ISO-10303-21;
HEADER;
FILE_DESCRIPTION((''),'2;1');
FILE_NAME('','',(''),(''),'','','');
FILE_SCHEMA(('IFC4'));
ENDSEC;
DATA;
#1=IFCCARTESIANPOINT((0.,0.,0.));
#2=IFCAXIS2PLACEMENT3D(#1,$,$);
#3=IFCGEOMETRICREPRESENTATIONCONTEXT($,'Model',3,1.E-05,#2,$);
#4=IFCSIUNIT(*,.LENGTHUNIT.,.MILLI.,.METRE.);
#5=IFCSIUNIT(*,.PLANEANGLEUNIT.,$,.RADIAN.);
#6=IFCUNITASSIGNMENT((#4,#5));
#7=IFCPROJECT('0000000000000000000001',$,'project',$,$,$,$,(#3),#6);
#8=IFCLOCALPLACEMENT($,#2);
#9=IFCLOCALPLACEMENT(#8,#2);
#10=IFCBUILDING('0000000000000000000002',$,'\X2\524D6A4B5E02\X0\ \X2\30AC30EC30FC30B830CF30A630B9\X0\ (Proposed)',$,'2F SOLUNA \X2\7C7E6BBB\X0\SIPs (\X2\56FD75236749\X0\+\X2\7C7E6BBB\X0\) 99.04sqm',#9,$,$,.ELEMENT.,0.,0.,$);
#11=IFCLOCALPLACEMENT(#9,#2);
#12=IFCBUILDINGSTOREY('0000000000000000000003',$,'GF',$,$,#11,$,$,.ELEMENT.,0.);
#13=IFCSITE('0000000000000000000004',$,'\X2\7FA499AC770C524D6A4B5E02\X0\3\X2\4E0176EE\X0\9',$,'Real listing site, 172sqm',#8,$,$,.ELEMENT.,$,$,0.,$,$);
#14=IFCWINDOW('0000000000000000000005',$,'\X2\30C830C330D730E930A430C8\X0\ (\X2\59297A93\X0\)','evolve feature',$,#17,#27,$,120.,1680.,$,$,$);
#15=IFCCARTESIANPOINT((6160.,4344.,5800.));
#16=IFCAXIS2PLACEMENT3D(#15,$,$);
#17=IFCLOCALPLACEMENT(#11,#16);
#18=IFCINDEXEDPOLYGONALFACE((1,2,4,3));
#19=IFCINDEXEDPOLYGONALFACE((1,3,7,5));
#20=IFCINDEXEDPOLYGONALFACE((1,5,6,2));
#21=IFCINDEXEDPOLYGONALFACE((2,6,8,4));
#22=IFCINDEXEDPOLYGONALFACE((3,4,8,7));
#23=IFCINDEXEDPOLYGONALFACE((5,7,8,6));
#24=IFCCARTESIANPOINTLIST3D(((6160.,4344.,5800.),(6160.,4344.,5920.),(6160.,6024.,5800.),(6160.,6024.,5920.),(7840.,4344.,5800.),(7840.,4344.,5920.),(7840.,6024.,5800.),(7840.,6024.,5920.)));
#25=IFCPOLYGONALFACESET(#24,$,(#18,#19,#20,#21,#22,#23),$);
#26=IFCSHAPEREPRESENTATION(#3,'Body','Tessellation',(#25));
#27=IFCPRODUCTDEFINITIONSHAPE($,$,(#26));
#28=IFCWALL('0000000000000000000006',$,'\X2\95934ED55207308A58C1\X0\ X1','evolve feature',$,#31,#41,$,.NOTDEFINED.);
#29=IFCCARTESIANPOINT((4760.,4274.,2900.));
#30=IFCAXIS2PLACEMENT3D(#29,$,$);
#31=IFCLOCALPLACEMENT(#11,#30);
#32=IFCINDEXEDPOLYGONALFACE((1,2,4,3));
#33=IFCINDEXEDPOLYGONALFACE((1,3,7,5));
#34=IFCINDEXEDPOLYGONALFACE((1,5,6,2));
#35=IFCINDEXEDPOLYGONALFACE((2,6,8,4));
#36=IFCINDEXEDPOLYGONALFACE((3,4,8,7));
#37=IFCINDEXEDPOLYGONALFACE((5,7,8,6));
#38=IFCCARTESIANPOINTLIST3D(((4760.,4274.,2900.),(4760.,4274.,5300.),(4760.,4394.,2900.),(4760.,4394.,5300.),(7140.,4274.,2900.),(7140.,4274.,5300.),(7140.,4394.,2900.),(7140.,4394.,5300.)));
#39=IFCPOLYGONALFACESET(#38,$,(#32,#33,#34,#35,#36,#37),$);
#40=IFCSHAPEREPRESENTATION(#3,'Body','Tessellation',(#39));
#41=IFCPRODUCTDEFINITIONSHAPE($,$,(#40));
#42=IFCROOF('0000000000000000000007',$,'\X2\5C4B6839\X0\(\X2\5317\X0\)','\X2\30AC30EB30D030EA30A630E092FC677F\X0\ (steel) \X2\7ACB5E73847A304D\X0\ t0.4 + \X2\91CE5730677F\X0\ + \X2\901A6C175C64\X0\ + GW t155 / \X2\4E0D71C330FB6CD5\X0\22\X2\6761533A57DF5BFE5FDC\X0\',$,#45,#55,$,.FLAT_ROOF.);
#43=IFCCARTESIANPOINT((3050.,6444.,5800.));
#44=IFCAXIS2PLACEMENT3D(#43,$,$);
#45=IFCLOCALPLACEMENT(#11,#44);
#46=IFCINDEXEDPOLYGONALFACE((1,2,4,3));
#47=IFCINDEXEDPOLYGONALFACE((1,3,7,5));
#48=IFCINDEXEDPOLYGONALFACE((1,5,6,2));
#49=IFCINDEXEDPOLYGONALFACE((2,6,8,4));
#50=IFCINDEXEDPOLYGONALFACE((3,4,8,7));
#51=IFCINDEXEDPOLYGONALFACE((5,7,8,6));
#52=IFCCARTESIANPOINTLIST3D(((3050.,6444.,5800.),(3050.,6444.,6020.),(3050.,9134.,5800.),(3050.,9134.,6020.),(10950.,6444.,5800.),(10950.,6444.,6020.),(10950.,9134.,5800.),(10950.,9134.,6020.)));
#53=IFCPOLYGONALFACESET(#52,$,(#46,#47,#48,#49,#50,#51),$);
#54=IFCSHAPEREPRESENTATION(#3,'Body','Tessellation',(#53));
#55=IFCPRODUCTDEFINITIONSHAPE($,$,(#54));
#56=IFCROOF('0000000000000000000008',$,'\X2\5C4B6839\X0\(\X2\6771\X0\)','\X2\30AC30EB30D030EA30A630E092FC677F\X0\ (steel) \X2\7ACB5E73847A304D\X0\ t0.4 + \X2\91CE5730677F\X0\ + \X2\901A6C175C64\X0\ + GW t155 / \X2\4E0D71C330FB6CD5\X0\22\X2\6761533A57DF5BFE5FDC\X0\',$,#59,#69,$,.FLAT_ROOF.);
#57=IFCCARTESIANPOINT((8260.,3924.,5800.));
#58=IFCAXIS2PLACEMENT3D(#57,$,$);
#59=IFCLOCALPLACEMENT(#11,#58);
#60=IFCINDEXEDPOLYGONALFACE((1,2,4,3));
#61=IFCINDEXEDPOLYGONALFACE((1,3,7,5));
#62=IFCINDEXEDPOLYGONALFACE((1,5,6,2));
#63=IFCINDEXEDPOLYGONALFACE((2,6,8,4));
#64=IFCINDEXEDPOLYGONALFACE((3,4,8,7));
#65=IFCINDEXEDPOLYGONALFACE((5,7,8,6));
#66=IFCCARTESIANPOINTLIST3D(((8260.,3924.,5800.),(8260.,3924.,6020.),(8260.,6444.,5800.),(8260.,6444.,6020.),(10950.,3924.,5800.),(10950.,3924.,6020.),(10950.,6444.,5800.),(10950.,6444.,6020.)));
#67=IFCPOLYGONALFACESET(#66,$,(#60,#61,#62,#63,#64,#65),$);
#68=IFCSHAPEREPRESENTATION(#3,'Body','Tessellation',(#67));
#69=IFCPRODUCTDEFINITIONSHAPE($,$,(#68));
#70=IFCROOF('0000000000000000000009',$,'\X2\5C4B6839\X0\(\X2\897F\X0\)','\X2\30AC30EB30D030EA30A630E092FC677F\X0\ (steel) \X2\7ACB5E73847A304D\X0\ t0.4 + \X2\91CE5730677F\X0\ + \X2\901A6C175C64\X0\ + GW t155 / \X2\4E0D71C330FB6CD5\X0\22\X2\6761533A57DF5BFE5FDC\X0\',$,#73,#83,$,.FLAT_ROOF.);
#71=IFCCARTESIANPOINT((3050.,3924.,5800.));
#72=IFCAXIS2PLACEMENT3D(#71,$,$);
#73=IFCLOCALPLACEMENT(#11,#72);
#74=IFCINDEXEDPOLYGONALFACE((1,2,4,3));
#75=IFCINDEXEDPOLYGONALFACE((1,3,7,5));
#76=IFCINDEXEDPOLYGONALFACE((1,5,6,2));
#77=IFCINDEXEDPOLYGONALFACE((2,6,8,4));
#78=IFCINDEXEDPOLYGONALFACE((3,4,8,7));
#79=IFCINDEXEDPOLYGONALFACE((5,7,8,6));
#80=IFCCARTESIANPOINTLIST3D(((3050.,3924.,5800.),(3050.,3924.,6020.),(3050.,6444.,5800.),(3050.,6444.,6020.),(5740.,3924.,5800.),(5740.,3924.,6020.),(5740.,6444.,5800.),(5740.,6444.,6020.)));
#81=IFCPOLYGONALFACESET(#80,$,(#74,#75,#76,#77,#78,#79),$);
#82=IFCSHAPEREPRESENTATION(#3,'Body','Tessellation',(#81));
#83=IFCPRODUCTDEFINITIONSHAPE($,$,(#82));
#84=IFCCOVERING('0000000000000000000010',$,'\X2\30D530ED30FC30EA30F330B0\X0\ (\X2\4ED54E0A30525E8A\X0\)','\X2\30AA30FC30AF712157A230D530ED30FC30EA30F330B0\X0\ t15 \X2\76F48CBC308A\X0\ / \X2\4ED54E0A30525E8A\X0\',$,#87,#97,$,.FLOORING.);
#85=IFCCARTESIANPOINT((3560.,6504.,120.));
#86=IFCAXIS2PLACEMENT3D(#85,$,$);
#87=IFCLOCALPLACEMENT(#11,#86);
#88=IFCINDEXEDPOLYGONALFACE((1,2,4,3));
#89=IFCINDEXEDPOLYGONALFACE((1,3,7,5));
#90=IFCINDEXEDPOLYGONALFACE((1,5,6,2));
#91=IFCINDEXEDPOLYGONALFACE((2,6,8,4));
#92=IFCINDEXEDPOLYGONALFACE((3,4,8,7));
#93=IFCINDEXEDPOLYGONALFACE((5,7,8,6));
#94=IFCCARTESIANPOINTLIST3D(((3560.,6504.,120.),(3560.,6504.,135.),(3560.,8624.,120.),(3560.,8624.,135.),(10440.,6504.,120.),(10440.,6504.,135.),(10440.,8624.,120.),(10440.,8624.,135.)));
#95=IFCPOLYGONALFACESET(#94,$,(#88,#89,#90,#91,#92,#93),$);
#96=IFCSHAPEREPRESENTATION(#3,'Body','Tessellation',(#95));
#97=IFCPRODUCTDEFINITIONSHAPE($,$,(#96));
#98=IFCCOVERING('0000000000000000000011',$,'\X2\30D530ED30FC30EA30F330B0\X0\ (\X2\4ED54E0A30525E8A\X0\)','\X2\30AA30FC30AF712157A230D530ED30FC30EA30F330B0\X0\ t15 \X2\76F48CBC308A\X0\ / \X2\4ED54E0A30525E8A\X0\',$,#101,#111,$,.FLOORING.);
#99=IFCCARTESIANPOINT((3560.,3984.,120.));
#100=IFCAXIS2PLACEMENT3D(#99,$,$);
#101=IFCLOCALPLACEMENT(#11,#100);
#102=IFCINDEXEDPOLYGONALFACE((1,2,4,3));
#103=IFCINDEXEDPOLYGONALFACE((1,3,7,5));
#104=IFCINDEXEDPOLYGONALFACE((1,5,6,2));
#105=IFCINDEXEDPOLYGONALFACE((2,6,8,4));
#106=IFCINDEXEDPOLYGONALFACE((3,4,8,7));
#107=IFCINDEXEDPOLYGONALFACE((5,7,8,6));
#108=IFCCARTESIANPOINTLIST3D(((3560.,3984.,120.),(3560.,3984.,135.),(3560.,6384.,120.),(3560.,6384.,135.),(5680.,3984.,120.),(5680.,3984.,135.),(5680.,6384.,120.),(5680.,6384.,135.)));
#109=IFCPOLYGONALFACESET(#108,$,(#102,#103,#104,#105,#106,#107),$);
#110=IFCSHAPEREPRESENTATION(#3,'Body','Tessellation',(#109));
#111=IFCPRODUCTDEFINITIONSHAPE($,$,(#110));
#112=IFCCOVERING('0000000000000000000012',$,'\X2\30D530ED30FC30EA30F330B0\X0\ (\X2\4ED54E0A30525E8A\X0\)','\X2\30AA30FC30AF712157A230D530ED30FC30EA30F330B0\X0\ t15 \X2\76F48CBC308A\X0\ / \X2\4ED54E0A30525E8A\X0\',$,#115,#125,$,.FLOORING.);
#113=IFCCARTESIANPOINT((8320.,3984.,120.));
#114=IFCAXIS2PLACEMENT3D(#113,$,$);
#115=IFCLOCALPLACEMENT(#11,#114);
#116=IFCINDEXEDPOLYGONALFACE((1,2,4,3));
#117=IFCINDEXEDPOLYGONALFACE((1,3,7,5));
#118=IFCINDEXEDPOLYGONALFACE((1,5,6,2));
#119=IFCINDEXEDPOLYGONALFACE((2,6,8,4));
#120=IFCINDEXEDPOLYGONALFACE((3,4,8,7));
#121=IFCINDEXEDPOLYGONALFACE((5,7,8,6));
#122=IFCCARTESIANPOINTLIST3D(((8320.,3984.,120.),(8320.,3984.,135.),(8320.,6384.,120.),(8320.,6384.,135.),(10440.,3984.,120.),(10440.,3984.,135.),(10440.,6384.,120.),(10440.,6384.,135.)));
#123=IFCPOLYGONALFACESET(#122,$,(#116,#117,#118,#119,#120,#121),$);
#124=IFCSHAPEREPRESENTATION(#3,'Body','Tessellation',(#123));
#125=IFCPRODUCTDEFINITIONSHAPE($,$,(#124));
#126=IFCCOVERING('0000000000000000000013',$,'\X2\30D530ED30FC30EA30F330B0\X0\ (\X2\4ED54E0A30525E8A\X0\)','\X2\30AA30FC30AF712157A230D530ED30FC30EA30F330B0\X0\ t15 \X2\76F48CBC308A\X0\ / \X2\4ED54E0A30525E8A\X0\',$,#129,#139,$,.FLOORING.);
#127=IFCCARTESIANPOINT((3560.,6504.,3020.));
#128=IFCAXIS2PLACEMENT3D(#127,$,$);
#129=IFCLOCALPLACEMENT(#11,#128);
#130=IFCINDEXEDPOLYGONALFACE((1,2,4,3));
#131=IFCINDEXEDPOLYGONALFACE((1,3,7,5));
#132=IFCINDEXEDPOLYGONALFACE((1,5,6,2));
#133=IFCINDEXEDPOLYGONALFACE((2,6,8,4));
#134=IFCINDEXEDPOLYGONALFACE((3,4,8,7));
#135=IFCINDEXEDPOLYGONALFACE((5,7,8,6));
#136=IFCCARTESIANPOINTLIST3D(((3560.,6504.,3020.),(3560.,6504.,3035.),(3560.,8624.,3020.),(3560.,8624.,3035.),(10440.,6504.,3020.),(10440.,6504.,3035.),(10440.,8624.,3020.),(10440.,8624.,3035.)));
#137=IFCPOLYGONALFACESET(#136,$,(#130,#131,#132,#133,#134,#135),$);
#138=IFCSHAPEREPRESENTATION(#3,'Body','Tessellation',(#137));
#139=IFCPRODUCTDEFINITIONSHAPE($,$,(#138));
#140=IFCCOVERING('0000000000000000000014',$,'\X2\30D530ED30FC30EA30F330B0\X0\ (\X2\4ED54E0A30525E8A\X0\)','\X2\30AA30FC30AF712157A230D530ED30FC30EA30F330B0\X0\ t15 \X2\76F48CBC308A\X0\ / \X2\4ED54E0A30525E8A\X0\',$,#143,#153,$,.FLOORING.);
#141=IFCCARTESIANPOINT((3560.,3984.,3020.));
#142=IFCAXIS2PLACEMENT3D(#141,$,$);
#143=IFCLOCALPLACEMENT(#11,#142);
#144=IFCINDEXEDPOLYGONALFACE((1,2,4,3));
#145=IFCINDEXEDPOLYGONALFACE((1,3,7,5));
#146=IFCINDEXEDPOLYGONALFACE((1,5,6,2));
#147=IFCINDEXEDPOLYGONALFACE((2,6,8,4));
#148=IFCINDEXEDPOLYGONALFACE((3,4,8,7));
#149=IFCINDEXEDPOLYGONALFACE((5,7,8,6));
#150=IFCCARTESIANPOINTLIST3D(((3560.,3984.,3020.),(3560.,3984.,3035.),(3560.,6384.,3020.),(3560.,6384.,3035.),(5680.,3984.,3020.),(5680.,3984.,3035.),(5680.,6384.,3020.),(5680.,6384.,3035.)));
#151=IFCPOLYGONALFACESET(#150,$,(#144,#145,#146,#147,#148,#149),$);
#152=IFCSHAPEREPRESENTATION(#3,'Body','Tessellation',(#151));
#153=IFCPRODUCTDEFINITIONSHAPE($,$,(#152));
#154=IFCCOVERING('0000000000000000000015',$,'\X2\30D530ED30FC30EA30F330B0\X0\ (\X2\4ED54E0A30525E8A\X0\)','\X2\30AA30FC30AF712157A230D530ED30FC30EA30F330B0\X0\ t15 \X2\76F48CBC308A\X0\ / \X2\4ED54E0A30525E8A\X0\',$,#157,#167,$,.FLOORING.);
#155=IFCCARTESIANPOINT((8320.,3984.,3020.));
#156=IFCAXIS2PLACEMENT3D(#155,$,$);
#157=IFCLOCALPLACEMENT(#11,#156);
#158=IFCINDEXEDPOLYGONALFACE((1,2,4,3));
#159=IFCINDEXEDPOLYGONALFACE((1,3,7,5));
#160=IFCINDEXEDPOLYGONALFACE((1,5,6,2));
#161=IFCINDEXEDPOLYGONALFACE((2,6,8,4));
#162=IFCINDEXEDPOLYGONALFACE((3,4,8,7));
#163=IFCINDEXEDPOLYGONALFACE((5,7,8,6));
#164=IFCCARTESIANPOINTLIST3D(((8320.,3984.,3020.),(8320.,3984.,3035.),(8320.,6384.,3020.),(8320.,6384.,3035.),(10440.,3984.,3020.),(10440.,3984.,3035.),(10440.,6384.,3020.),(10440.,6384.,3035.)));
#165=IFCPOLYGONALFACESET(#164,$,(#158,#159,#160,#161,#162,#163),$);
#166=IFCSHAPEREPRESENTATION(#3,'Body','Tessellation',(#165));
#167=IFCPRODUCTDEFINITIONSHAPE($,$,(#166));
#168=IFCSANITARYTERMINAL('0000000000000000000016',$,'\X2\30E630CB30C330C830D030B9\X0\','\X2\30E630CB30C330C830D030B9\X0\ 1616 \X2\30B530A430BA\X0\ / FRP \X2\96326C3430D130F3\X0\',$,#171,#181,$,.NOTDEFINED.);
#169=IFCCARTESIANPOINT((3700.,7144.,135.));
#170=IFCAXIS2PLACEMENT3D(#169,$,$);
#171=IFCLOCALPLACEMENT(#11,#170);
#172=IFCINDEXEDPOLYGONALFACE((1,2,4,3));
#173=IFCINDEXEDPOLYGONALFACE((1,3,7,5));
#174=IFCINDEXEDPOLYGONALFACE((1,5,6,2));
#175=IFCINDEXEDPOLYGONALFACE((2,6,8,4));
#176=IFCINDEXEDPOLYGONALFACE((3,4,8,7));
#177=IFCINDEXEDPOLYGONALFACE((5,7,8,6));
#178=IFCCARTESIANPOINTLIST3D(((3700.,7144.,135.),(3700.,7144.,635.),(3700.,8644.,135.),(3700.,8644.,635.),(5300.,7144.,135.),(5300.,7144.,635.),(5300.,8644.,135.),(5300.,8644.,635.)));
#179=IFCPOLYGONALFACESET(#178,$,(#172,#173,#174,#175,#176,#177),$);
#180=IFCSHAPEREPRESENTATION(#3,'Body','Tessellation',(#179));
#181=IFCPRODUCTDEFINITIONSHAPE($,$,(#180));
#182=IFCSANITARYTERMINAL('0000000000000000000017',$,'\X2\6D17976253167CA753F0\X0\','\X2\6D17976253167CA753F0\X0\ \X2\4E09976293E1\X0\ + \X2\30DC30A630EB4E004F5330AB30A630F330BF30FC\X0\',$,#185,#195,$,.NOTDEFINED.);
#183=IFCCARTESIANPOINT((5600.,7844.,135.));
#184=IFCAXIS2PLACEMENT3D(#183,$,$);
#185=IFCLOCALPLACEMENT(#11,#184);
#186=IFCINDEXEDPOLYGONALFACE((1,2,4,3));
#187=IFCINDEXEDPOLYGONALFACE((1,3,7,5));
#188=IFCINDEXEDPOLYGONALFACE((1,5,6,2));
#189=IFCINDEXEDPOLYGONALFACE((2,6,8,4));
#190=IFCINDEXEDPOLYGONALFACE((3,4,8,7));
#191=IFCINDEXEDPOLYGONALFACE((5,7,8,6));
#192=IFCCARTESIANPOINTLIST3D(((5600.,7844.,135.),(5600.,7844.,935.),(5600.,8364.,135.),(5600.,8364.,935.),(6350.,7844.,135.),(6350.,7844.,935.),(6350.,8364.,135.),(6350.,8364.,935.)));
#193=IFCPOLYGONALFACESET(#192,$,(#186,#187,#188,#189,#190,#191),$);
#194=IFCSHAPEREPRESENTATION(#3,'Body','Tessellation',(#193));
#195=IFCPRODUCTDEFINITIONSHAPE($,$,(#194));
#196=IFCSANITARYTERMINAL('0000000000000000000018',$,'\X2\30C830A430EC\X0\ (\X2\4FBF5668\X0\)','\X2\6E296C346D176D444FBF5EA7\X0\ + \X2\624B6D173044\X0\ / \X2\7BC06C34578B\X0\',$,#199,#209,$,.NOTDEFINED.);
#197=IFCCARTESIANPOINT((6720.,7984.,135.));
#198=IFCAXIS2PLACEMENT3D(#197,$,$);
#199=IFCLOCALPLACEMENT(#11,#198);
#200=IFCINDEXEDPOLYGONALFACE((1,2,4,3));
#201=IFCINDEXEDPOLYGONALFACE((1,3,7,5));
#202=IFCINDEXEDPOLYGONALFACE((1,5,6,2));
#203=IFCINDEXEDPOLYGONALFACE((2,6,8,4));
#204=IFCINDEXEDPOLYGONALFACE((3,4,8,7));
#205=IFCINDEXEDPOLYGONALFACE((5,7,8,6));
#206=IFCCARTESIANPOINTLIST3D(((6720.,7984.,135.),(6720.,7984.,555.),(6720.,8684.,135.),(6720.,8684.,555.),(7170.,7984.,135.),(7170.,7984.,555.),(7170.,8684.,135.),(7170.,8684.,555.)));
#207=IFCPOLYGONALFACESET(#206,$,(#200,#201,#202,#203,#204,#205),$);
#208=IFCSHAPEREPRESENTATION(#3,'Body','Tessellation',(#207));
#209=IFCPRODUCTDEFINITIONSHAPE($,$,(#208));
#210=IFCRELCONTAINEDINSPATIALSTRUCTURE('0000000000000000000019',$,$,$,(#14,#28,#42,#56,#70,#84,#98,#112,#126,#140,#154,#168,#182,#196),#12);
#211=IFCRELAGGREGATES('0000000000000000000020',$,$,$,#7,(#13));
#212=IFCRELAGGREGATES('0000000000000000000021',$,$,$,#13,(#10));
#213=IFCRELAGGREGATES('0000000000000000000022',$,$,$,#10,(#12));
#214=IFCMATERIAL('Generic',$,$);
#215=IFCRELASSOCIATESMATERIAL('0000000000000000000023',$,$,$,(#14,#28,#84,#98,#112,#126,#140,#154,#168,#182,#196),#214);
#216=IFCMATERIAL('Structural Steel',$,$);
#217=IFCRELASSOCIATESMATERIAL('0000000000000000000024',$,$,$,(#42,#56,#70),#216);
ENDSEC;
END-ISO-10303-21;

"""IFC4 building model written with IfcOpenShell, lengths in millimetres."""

from ifc_helpers import new_model, si_unit, frame, frame_2d, origin, place, context, project, spatial, rectangle, extrude, material, element, save


model = new_model("IFC4")

# Units and contexts
model_context = context("Model", 3, precision=1e-05, world=origin())
ifc_project = project(units=[si_unit("LENGTHUNIT", "METRE", prefix="MILLI"), si_unit("PLANEANGLEUNIT", "RADIAN")], contexts=[model_context])

# Site, building, storey
site_placement = place(None, origin())
site = spatial("IfcSite", under=ifc_project, at=site_placement, Name="群馬県前橋市3丁目9", ObjectType="Real listing site, 172sqm", CompositionType="ELEMENT", RefElevation=0.0)
building_placement = place(site_placement, origin())
building = spatial("IfcBuilding", under=site, at=building_placement, Name="前橋市 ガレージハウス (Proposed)", ObjectType="2F SOLUNA 籾殻SIPs (国産杉+籾殻) 99.04sqm", CompositionType="ELEMENT", ElevationOfRefHeight=0.0, ElevationOfTerrain=0.0)
storey_placement = place(building_placement, origin())
storey = spatial("IfcBuildingStorey", under=building, at=storey_placement, Name="GF", CompositionType="ELEMENT", Elevation=0.0)

# Window
ifc_material_1 = material(Name="Generic")
window_1_placement = place(storey_placement, frame((6160.0, 4344.0, 5800.0)))
element("IfcWindow", 1, at=window_1_placement, inside=storey, material=ifc_material_1, Name="トップライト (天窓)", Description="evolve feature", OverallHeight=120.0, OverallWidth=1680.0, context=model_context, shape_type="SweptSolid", body=[
    extrude(rectangle(XDim=1680.0, YDim=1680.0, at=frame_2d((840.0, 840.0))), frame((6160.0, 4344.0, 5800.0)), (0.0, 0.0, 1.0), 120.0),
])

# Wall
wall_1_placement = place(storey_placement, frame((4760.0, 4274.0, 2900.0)))
element("IfcWall", 2, at=wall_1_placement, inside=storey, material=ifc_material_1, Name="間仕切り壁 X1", Description="evolve feature", PredefinedType="NOTDEFINED", context=model_context, shape_type="SweptSolid", body=[
    extrude(rectangle(XDim=2380.0, YDim=120.0, at=frame_2d((1190.0, 60.0))), frame((4760.0, 4274.0, 2900.0)), (0.0, 0.0, 1.0), 2400.0),
])

# Roofs
ifc_material_2 = material(Name="Structural Steel")
roof_1_placement = place(storey_placement, frame((3050.0, 6444.0, 5800.0)))
element("IfcRoof", 3, at=roof_1_placement, inside=storey, material=ifc_material_2, Name="屋根(北)", Description="ガルバリウム鋼板 (steel) 立平葺き t0.4 + 野地板 + 通気層 + GW t155 / 不燃・法22条区域対応", PredefinedType="FLAT_ROOF", context=model_context, shape_type="SweptSolid", body=[
    extrude(rectangle(XDim=7900.0, YDim=2690.0, at=frame_2d((3950.0, 1345.0))), frame((3050.0, 6444.0, 5800.0)), (0.0, 0.0, 1.0), 220.0),
])
roof_2_placement = place(storey_placement, frame((8260.0, 3924.0, 5800.0)))
element("IfcRoof", 4, at=roof_2_placement, inside=storey, material=ifc_material_2, Name="屋根(東)", Description="ガルバリウム鋼板 (steel) 立平葺き t0.4 + 野地板 + 通気層 + GW t155 / 不燃・法22条区域対応", PredefinedType="FLAT_ROOF", context=model_context, shape_type="SweptSolid", body=[
    extrude(rectangle(XDim=2690.0, YDim=2520.0, at=frame_2d((1345.0, 1260.0))), frame((8260.0, 3924.0, 5800.0)), (0.0, 0.0, 1.0), 220.0),
])
roof_3_placement = place(storey_placement, frame((3050.0, 3924.0, 5800.0)))
element("IfcRoof", 5, at=roof_3_placement, inside=storey, material=ifc_material_2, Name="屋根(西)", Description="ガルバリウム鋼板 (steel) 立平葺き t0.4 + 野地板 + 通気層 + GW t155 / 不燃・法22条区域対応", PredefinedType="FLAT_ROOF", context=model_context, shape_type="SweptSolid", body=[
    extrude(rectangle(XDim=2690.0, YDim=2520.0, at=frame_2d((1345.0, 1260.0))), frame((3050.0, 3924.0, 5800.0)), (0.0, 0.0, 1.0), 220.0),
])

# Coverings
covering_1_placement = place(storey_placement, frame((3560.0, 6504.0, 120.0)))
element("IfcCovering", 6, at=covering_1_placement, inside=storey, material=ifc_material_1, Name="フローリング (仕上げ床)", Description="オーク無垢フローリング t15 直貼り / 仕上げ床", PredefinedType="FLOORING", context=model_context, shape_type="SweptSolid", body=[
    extrude(rectangle(XDim=6880.0, YDim=2120.0, at=frame_2d((3440.0, 1060.0))), frame((3560.0, 6504.0, 120.0)), (0.0, 0.0, 1.0), 15.0),
])
covering_2_placement = place(storey_placement, frame((3560.0, 3984.0, 120.0)))
element("IfcCovering", 7, at=covering_2_placement, inside=storey, material=ifc_material_1, Name="フローリング (仕上げ床)", Description="オーク無垢フローリング t15 直貼り / 仕上げ床", PredefinedType="FLOORING", context=model_context, shape_type="SweptSolid", body=[
    extrude(rectangle(XDim=2120.0, YDim=2400.0, at=frame_2d((1060.0, 1200.0))), frame((3560.0, 3984.0, 120.0)), (0.0, 0.0, 1.0), 15.0),
])
covering_3_placement = place(storey_placement, frame((8320.0, 3984.0, 120.0)))
element("IfcCovering", 8, at=covering_3_placement, inside=storey, material=ifc_material_1, Name="フローリング (仕上げ床)", Description="オーク無垢フローリング t15 直貼り / 仕上げ床", PredefinedType="FLOORING", context=model_context, shape_type="SweptSolid", body=[
    extrude(rectangle(XDim=2120.0, YDim=2400.0, at=frame_2d((1060.0, 1200.0))), frame((8320.0, 3984.0, 120.0)), (0.0, 0.0, 1.0), 15.0),
])
covering_4_placement = place(storey_placement, frame((3560.0, 6504.0, 3020.0)))
element("IfcCovering", 9, at=covering_4_placement, inside=storey, material=ifc_material_1, Name="フローリング (仕上げ床)", Description="オーク無垢フローリング t15 直貼り / 仕上げ床", PredefinedType="FLOORING", context=model_context, shape_type="SweptSolid", body=[
    extrude(rectangle(XDim=6880.0, YDim=2120.0, at=frame_2d((3440.0, 1060.0))), frame((3560.0, 6504.0, 3020.0)), (0.0, 0.0, 1.0), 15.0),
])
covering_5_placement = place(storey_placement, frame((3560.0, 3984.0, 3020.0)))
element("IfcCovering", 10, at=covering_5_placement, inside=storey, material=ifc_material_1, Name="フローリング (仕上げ床)", Description="オーク無垢フローリング t15 直貼り / 仕上げ床", PredefinedType="FLOORING", context=model_context, shape_type="SweptSolid", body=[
    extrude(rectangle(XDim=2120.0, YDim=2400.0, at=frame_2d((1060.0, 1200.0))), frame((3560.0, 3984.0, 3020.0)), (0.0, 0.0, 1.0), 15.0),
])
covering_6_placement = place(storey_placement, frame((8320.0, 3984.0, 3020.0)))
element("IfcCovering", 11, at=covering_6_placement, inside=storey, material=ifc_material_1, Name="フローリング (仕上げ床)", Description="オーク無垢フローリング t15 直貼り / 仕上げ床", PredefinedType="FLOORING", context=model_context, shape_type="SweptSolid", body=[
    extrude(rectangle(XDim=2120.0, YDim=2400.0, at=frame_2d((1060.0, 1200.0))), frame((8320.0, 3984.0, 3020.0)), (0.0, 0.0, 1.0), 15.0),
])

# Sanitary terminals
sanitary_terminal_1_placement = place(storey_placement, frame((3700.0, 7144.0, 135.0)))
element("IfcSanitaryTerminal", 12, at=sanitary_terminal_1_placement, inside=storey, material=ifc_material_1, Name="ユニットバス", Description="ユニットバス 1616 サイズ / FRP 防水パン", PredefinedType="NOTDEFINED", context=model_context, shape_type="SweptSolid", body=[
    extrude(rectangle(XDim=1600.0, YDim=1500.0, at=frame_2d((800.0, 750.0))), frame((3700.0, 7144.0, 135.0)), (0.0, 0.0, 1.0), 500.0),
])
sanitary_terminal_2_placement = place(storey_placement, frame((5600.0, 7844.0, 135.0)))
element("IfcSanitaryTerminal", 13, at=sanitary_terminal_2_placement, inside=storey, material=ifc_material_1, Name="洗面化粧台", Description="洗面化粧台 三面鏡 + ボウル一体カウンター", PredefinedType="NOTDEFINED", context=model_context, shape_type="SweptSolid", body=[
    extrude(rectangle(XDim=750.0, YDim=520.0, at=frame_2d((375.0, 260.0))), frame((5600.0, 7844.0, 135.0)), (0.0, 0.0, 1.0), 800.0),
])
sanitary_terminal_3_placement = place(storey_placement, frame((6720.0, 7984.0, 135.0)))
element("IfcSanitaryTerminal", 14, at=sanitary_terminal_3_placement, inside=storey, material=ifc_material_1, Name="トイレ (便器)", Description="温水洗浄便座 + 手洗い / 節水型", PredefinedType="NOTDEFINED", context=model_context, shape_type="SweptSolid", body=[
    extrude(rectangle(XDim=450.0, YDim=700.0, at=frame_2d((225.0, 350.0))), frame((6720.0, 7984.0, 135.0)), (0.0, 0.0, 1.0), 420.0),
])

save(model, "model.ifc")
